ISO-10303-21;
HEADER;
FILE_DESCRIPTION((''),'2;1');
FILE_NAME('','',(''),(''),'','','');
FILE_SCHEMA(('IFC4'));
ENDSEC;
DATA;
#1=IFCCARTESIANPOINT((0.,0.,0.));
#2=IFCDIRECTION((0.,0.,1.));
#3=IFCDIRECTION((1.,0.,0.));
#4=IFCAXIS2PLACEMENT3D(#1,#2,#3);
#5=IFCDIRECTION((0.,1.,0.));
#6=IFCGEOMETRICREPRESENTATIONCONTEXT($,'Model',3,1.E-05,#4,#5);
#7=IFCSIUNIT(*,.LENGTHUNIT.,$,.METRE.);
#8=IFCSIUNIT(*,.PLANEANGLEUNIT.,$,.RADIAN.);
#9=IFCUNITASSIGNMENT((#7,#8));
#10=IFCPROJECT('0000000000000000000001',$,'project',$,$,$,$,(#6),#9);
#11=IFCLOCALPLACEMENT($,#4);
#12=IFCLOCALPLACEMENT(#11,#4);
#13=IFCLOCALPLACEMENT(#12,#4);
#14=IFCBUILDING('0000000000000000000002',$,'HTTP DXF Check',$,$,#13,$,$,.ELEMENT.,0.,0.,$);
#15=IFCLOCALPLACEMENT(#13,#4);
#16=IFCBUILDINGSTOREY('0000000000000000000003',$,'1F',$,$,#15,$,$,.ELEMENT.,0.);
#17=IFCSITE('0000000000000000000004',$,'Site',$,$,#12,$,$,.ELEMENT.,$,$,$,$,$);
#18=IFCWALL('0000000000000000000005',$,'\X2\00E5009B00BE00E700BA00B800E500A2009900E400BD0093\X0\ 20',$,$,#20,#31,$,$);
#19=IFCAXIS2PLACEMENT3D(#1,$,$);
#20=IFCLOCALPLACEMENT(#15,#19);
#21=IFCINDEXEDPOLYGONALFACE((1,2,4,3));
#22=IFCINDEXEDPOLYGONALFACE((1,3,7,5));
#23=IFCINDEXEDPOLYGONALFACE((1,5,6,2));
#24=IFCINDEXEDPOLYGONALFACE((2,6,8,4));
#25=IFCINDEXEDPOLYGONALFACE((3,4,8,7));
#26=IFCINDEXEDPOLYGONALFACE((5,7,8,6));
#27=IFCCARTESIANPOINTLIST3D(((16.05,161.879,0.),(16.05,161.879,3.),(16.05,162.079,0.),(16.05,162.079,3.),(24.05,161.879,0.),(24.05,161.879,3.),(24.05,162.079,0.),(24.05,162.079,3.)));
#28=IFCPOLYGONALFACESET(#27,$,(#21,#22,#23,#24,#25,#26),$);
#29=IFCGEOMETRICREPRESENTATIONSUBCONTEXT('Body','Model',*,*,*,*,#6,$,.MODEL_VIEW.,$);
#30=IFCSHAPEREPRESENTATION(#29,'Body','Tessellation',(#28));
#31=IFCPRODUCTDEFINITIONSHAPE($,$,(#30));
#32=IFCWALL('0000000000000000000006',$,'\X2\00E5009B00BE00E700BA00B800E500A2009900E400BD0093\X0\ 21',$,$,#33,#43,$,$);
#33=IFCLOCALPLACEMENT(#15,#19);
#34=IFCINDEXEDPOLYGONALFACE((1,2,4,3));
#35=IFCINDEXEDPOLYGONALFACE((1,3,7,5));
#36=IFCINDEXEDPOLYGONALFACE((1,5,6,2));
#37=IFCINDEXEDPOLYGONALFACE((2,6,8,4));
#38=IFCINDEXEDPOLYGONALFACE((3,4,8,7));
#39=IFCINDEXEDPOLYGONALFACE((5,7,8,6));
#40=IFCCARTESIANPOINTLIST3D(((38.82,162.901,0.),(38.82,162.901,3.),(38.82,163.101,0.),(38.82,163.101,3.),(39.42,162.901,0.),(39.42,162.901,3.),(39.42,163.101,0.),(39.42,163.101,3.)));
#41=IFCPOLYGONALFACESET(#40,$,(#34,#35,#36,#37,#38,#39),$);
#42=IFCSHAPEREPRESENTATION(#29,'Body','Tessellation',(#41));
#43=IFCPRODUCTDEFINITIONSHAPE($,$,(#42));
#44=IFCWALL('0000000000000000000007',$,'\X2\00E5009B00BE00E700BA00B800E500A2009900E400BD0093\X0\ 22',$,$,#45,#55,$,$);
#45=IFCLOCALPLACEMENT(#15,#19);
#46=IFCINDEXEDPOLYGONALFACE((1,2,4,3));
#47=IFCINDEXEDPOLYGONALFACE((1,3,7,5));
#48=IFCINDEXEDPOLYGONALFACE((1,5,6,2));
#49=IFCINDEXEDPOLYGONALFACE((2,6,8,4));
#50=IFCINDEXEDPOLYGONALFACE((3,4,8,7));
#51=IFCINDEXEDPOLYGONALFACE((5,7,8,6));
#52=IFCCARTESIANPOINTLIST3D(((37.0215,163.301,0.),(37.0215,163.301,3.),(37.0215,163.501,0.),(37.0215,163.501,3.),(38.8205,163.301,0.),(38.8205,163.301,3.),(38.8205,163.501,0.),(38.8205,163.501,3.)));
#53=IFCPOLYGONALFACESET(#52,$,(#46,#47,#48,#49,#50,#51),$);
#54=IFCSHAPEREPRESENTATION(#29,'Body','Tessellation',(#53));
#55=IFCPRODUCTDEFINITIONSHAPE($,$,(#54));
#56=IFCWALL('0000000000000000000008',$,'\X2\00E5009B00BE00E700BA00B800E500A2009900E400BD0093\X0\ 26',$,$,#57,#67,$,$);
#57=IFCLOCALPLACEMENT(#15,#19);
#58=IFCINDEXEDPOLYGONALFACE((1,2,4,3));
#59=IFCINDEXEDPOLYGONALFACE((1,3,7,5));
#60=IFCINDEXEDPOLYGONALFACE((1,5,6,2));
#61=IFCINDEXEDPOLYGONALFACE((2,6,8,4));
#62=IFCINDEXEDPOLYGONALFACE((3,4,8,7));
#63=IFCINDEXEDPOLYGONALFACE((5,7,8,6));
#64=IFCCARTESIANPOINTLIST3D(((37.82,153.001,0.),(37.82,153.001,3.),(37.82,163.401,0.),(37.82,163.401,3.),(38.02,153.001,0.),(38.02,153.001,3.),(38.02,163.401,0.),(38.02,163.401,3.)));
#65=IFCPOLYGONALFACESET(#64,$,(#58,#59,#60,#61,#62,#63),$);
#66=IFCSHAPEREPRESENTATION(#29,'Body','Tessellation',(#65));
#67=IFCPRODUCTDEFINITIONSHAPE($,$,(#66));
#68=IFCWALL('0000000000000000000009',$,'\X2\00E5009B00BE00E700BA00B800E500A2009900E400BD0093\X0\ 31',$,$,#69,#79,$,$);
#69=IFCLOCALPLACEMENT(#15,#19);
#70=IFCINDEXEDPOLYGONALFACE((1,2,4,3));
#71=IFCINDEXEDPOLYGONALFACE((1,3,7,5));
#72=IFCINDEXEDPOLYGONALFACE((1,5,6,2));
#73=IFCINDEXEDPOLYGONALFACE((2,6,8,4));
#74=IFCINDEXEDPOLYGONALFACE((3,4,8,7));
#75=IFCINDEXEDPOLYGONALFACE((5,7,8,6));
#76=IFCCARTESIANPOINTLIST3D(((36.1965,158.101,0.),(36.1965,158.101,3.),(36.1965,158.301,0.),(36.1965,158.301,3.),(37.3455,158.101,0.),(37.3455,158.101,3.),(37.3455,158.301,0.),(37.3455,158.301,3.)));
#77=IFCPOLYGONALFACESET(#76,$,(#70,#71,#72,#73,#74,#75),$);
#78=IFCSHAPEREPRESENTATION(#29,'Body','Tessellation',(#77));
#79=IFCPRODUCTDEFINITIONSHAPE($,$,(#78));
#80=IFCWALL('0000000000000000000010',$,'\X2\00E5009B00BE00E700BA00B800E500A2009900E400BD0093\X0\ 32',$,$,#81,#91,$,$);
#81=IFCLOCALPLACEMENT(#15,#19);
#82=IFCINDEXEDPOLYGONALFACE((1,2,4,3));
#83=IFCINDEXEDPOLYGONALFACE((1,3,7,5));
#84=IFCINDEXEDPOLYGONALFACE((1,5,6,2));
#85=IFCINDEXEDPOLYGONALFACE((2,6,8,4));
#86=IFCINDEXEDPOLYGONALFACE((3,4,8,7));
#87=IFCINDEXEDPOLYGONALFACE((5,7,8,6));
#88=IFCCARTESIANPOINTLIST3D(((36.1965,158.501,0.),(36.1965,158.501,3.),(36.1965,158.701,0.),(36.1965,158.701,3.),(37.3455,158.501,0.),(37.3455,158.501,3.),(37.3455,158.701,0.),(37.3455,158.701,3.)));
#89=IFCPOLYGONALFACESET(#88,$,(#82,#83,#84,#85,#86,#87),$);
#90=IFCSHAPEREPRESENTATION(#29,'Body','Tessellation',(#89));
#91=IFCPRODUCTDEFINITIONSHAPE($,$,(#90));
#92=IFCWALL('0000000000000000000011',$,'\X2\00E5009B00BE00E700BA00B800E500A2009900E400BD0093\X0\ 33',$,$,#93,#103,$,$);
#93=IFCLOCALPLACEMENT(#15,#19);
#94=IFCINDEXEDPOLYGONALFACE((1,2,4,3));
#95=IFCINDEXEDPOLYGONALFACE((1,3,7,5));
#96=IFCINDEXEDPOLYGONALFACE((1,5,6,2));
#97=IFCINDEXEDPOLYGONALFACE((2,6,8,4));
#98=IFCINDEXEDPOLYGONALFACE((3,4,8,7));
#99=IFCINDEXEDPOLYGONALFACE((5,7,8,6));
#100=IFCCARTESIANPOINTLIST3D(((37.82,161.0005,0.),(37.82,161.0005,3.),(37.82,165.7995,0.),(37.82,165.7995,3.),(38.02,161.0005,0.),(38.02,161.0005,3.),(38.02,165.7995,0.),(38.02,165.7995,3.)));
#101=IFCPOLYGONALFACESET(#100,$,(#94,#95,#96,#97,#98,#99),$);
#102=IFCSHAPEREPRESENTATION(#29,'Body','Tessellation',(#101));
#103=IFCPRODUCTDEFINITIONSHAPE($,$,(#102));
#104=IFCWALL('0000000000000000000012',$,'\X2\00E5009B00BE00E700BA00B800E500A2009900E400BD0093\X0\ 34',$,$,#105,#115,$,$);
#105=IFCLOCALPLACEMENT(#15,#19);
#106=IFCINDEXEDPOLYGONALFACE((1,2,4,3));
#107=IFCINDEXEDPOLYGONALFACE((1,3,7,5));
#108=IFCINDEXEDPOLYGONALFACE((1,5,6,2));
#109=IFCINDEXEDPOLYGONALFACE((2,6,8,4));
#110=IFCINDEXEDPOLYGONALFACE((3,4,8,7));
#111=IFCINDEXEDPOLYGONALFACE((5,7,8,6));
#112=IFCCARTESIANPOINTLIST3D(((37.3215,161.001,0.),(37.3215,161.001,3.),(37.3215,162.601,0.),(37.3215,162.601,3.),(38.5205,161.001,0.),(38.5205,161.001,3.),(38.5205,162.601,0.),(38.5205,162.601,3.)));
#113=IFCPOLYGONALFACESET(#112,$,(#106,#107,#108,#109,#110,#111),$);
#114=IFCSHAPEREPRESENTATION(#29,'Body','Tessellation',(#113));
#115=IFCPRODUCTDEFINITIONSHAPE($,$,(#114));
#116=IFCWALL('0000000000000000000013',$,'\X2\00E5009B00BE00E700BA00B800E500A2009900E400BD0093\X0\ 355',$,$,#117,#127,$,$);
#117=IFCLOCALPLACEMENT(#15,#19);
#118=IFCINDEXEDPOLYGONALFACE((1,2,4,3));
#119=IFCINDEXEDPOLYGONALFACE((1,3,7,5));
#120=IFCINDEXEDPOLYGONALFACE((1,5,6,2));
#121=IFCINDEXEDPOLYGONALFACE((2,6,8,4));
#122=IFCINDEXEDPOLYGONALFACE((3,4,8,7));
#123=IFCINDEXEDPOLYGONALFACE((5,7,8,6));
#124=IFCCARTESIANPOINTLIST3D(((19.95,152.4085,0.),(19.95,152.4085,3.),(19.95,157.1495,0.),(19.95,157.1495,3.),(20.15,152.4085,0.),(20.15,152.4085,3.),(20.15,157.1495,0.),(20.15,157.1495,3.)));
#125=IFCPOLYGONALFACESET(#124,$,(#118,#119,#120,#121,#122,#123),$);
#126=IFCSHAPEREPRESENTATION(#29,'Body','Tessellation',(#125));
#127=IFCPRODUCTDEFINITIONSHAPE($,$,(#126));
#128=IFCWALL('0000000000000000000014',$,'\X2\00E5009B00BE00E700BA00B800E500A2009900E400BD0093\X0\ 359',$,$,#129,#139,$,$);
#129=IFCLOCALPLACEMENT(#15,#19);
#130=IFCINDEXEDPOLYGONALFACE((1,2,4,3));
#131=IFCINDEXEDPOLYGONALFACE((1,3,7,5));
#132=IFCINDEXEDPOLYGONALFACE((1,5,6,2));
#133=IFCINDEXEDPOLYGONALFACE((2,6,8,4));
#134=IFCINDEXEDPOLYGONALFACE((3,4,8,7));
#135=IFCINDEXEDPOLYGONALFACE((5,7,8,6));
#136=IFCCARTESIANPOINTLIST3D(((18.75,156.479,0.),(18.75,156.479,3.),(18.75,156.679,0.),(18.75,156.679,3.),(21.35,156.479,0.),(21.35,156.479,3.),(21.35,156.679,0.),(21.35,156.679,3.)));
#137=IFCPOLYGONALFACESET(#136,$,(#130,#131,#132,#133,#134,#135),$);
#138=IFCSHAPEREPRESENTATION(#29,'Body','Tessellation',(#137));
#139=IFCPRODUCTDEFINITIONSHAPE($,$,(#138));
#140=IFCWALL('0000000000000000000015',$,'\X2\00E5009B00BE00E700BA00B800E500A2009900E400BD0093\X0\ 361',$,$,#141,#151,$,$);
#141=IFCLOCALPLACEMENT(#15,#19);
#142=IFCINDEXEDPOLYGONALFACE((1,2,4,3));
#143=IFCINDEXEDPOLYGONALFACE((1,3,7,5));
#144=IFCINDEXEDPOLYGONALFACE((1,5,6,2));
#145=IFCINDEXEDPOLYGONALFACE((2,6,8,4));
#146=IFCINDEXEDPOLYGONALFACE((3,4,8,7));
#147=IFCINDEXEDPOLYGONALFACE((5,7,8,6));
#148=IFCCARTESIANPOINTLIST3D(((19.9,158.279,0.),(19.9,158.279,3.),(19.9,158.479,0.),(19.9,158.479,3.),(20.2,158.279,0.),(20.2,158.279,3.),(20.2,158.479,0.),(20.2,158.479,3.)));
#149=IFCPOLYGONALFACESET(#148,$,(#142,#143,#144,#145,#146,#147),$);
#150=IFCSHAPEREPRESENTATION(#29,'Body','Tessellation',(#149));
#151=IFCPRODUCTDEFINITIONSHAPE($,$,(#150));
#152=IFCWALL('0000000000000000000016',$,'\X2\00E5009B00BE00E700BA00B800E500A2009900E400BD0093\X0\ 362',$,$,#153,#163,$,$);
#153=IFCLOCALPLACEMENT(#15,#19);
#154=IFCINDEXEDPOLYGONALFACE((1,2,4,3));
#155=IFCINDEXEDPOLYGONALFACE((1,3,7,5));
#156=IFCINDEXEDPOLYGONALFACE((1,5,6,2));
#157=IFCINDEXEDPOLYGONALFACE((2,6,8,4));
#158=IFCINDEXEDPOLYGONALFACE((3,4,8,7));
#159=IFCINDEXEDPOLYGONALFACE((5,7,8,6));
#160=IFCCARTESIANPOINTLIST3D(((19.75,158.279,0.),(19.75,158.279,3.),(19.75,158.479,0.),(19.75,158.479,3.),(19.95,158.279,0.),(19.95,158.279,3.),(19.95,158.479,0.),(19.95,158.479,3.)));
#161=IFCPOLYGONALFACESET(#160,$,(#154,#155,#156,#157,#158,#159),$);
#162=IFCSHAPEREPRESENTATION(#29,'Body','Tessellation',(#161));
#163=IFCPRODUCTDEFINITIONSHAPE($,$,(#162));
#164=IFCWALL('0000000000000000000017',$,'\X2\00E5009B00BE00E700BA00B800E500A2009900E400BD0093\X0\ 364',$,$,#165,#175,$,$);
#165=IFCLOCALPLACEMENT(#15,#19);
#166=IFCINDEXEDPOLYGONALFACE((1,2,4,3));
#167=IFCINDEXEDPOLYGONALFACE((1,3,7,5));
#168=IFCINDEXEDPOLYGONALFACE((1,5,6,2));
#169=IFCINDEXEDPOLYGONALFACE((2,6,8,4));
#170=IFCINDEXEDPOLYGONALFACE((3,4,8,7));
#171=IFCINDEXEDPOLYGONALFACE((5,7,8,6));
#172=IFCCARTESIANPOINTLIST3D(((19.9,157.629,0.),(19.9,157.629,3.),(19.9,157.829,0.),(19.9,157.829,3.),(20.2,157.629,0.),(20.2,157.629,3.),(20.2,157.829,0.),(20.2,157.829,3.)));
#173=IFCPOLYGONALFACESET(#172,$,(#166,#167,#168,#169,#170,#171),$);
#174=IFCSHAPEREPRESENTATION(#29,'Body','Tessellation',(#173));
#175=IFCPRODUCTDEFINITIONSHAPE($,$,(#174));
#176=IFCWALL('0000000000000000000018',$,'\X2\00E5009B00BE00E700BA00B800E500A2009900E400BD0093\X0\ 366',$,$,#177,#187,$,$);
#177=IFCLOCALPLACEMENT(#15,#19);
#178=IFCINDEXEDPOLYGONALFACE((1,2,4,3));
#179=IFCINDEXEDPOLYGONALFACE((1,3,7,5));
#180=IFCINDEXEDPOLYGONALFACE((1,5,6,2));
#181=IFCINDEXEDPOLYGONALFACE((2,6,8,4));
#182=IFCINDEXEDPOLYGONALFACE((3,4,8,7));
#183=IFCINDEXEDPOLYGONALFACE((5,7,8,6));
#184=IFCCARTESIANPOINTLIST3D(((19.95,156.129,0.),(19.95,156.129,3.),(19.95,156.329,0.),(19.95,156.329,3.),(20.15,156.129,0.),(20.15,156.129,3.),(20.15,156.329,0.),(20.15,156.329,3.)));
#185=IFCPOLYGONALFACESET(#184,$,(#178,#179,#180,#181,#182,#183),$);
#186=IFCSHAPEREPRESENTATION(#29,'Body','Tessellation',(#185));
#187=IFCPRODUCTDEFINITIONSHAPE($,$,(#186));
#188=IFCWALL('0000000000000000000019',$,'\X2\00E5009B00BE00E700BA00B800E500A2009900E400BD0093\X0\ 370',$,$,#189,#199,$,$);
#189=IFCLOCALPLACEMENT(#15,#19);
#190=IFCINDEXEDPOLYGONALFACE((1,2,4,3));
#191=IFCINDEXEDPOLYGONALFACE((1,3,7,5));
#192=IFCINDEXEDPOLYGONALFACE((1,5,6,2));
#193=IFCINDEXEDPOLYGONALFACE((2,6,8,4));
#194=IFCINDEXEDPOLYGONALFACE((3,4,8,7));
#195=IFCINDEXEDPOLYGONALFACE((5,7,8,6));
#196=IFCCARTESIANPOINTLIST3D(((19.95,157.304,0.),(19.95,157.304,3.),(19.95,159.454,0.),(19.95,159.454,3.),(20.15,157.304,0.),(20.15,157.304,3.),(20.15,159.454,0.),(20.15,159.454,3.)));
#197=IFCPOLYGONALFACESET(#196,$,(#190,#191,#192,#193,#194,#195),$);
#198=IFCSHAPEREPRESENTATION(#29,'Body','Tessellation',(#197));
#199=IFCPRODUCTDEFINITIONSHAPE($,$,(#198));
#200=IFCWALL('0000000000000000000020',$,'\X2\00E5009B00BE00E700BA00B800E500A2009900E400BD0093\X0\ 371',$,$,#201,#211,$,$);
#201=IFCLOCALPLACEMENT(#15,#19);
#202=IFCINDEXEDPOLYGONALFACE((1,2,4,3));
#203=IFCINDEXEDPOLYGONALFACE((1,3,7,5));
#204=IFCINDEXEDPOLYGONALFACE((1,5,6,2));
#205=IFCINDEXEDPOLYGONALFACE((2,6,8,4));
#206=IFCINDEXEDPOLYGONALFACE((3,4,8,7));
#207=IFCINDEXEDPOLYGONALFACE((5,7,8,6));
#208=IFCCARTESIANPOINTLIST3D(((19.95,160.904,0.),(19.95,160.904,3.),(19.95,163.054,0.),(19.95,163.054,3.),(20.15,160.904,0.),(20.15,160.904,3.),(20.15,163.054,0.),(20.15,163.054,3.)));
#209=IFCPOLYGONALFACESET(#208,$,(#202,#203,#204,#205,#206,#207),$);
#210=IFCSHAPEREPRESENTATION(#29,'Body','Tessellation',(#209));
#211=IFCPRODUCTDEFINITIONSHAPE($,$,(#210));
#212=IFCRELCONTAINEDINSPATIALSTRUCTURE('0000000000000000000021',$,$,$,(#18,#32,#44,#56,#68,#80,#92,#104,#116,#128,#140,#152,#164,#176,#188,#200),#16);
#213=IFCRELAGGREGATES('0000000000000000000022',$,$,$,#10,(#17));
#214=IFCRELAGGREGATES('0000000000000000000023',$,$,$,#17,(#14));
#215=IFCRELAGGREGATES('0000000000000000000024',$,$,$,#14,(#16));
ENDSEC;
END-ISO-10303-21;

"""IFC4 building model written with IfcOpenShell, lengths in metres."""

from ifc_helpers import new_model, si_unit, direction, frame, frame_2d, origin_with_axes, place, context, subcontext, project, spatial, rectangle, extrude, element, save


model = new_model("IFC4")

# Units and contexts
model_context = context("Model", 3, precision=1e-05, world=origin_with_axes(), true_north=direction((0.0, 1.0, 0.0)))
body_context = subcontext(model_context, "Body", "Model", "MODEL_VIEW")
ifc_project = project(units=[si_unit("LENGTHUNIT", "METRE"), si_unit("PLANEANGLEUNIT", "RADIAN")], contexts=[model_context])

# Site, building, storey
placement = place(None, origin_with_axes())
site_placement = place(placement, origin_with_axes())
site = spatial("IfcSite", under=ifc_project, at=site_placement, Name="Site", CompositionType="ELEMENT")
building_placement = place(site_placement, origin_with_axes())
building = spatial("IfcBuilding", under=site, at=building_placement, Name="HTTP DXF Check", CompositionType="ELEMENT", ElevationOfRefHeight=0.0, ElevationOfTerrain=0.0)
storey_placement = place(building_placement, origin_with_axes())
storey = spatial("IfcBuildingStorey", under=building, at=storey_placement, Name="1F", CompositionType="ELEMENT", Elevation=0.0)

# Walls
wall_1_placement = place(storey_placement, frame((20.05, 161.979, 0.0), z_axis=(0.0, 0.0, 1.0), x_axis=(-1.0, 0.0, 0.0)))
element("IfcWall", 1, at=wall_1_placement, inside=storey, Name="å\u009b¾çº¸å¢\u0099ä½\u0093 20", context=body_context, shape_type="SweptSolid", body=[
    extrude(rectangle(XDim=8.0, YDim=0.2, at=frame_2d((0.0, 0.0), x_axis=(1.0, 0.0, 0.0))), frame((0.0, 0.0, 0.0), z_axis=(0.0, 0.0, 1.0)), (0.0, 0.0, 1.0), 3.0),
])
wall_2_placement = place(storey_placement, frame((39.12, 163.001, 0.0), z_axis=(0.0, 0.0, 1.0), x_axis=(1.0, 0.0, 0.0)))
element("IfcWall", 2, at=wall_2_placement, inside=storey, Name="å\u009b¾çº¸å¢\u0099ä½\u0093 21", context=body_context, shape_type="SweptSolid", body=[
    extrude(rectangle(XDim=0.6, YDim=0.2, at=frame_2d((0.0, 0.0), x_axis=(1.0, 0.0, 0.0))), frame((0.0, 0.0, 0.0), z_axis=(0.0, 0.0, 1.0)), (0.0, 0.0, 1.0), 3.0),
])
wall_3_placement = place(storey_placement, frame((37.921, 163.401, 0.0), z_axis=(0.0, 0.0, 1.0), x_axis=(1.0, 0.0, 0.0)))
element("IfcWall", 3, at=wall_3_placement, inside=storey, Name="å\u009b¾çº¸å¢\u0099ä½\u0093 22", context=body_context, shape_type="SweptSolid", body=[
    extrude(rectangle(XDim=1.799, YDim=0.2, at=frame_2d((0.0, 0.0), x_axis=(1.0, 0.0, 0.0))), frame((0.0, 0.0, 0.0), z_axis=(0.0, 0.0, 1.0)), (0.0, 0.0, 1.0), 3.0),
])
wall_4_placement = place(storey_placement, frame((37.92, 158.201, 0.0), z_axis=(0.0, 0.0, 1.0), x_axis=(0.0, -1.0, 0.0)))
element("IfcWall", 4, at=wall_4_placement, inside=storey, Name="å\u009b¾çº¸å¢\u0099ä½\u0093 26", context=body_context, shape_type="SweptSolid", body=[
    extrude(rectangle(XDim=10.4, YDim=0.2, at=frame_2d((0.0, 0.0), x_axis=(1.0, 0.0, 0.0))), frame((0.0, 0.0, 0.0), z_axis=(0.0, 0.0, 1.0)), (0.0, 0.0, 1.0), 3.0),
])
for number, where, z_axis, x_axis, name in (
    (5, (36.771, 158.201, 0.0), (0.0, 0.0, 1.0), (1.0, 0.0, 0.0), "å\u009b¾çº¸å¢\u0099ä½\u0093 31"),
    (6, (36.771, 158.601, 0.0), (0.0, 0.0, 1.0), (1.0, 0.0, 0.0), "å\u009b¾çº¸å¢\u0099ä½\u0093 32"),
):
    element("IfcWall", number, at=place(storey_placement, frame(where, z_axis=z_axis, x_axis=x_axis)), inside=storey, Name=name, context=body_context, shape_type="SweptSolid", body=[
        extrude(rectangle(XDim=1.149, YDim=0.2, at=frame_2d((0.0, 0.0), x_axis=(1.0, 0.0, 0.0))), frame((0.0, 0.0, 0.0), z_axis=(0.0, 0.0, 1.0)), (0.0, 0.0, 1.0), 3.0),
    ])
wall_5_placement = place(storey_placement, frame((37.92, 163.4, 0.0), z_axis=(0.0, 0.0, 1.0), x_axis=(0.0, -1.0, 0.0)))
element("IfcWall", 7, at=wall_5_placement, inside=storey, Name="å\u009b¾çº¸å¢\u0099ä½\u0093 33", context=body_context, shape_type="SweptSolid", body=[
    extrude(rectangle(XDim=4.799, YDim=0.2, at=frame_2d((0.0, 0.0), x_axis=(1.0, 0.0, 0.0))), frame((0.0, 0.0, 0.0), z_axis=(0.0, 0.0, 1.0)), (0.0, 0.0, 1.0), 3.0),
])
wall_6_placement = place(storey_placement, frame((37.921, 161.801, 0.0), z_axis=(0.0, 0.0, 1.0), x_axis=(1.0, 0.0, 0.0)))
element("IfcWall", 8, at=wall_6_placement, inside=storey, Name="å\u009b¾çº¸å¢\u0099ä½\u0093 34", context=body_context, shape_type="SweptSolid", body=[
    extrude(rectangle(XDim=1.199, YDim=1.6, at=frame_2d((0.0, 0.0), x_axis=(1.0, 0.0, 0.0))), frame((0.0, 0.0, 0.0), z_axis=(0.0, 0.0, 1.0)), (0.0, 0.0, 1.0), 3.0),
])
wall_7_placement = place(storey_placement, frame((20.05, 154.779, 0.0), z_axis=(0.0, 0.0, 1.0), x_axis=(0.0, -1.0, 0.0)))
element("IfcWall", 9, at=wall_7_placement, inside=storey, Name="å\u009b¾çº¸å¢\u0099ä½\u0093 355", context=body_context, shape_type="SweptSolid", body=[
    extrude(rectangle(XDim=4.741, YDim=0.2, at=frame_2d((0.0, 0.0), x_axis=(1.0, 0.0, 0.0))), frame((0.0, 0.0, 0.0), z_axis=(0.0, 0.0, 1.0)), (0.0, 0.0, 1.0), 3.0),
])
wall_8_placement = place(storey_placement, frame((20.05, 156.579, 0.0), z_axis=(0.0, 0.0, 1.0), x_axis=(-1.0, 0.0, 0.0)))
element("IfcWall", 10, at=wall_8_placement, inside=storey, Name="å\u009b¾çº¸å¢\u0099ä½\u0093 359", context=body_context, shape_type="SweptSolid", body=[
    extrude(rectangle(XDim=2.6, YDim=0.2, at=frame_2d((0.0, 0.0), x_axis=(1.0, 0.0, 0.0))), frame((0.0, 0.0, 0.0), z_axis=(0.0, 0.0, 1.0)), (0.0, 0.0, 1.0), 3.0),
])
wall_9_placement = place(storey_placement, frame((20.05, 158.379, 0.0), z_axis=(0.0, 0.0, 1.0), x_axis=(-1.0, 0.0, 0.0)))
element("IfcWall", 11, at=wall_9_placement, inside=storey, Name="å\u009b¾çº¸å¢\u0099ä½\u0093 361", context=body_context, shape_type="SweptSolid", body=[
    extrude(rectangle(XDim=0.3, YDim=0.2, at=frame_2d((0.0, 0.0), x_axis=(1.0, 0.0, 0.0))), frame((0.0, 0.0, 0.0), z_axis=(0.0, 0.0, 1.0)), (0.0, 0.0, 1.0), 3.0),
])
wall_10_placement = place(storey_placement, frame((19.85, 158.379, 0.0), z_axis=(0.0, 0.0, 1.0), x_axis=(1.0, 0.0, 0.0)))
element("IfcWall", 12, at=wall_10_placement, inside=storey, Name="å\u009b¾çº¸å¢\u0099ä½\u0093 362", context=body_context, shape_type="SweptSolid", body=[
    extrude(rectangle(XDim=0.2, YDim=0.2, at=frame_2d((0.0, 0.0), x_axis=(1.0, 0.0, 0.0))), frame((0.0, 0.0, 0.0), z_axis=(0.0, 0.0, 1.0)), (0.0, 0.0, 1.0), 3.0),
])
for number, where, z_axis, x_axis, name in (
    (13, (20.05, 157.729, 0.0), (0.0, 0.0, 1.0), (-1.0, 0.0, 0.0), "å\u009b¾çº¸å¢\u0099ä½\u0093 364"),
):
    element("IfcWall", number, at=place(storey_placement, frame(where, z_axis=z_axis, x_axis=x_axis)), inside=storey, Name=name, context=body_context, shape_type="SweptSolid", body=[
        extrude(rectangle(XDim=0.3, YDim=0.2, at=frame_2d((0.0, 0.0), x_axis=(1.0, 0.0, 0.0))), frame((0.0, 0.0, 0.0), z_axis=(0.0, 0.0, 1.0)), (0.0, 0.0, 1.0), 3.0),
    ])
wall_11_placement = place(storey_placement, frame((20.05, 156.229, 0.0), z_axis=(0.0, 0.0, 1.0), x_axis=(-1.0, 0.0, 0.0)))
element("IfcWall", 14, at=wall_11_placement, inside=storey, Name="å\u009b¾çº¸å¢\u0099ä½\u0093 366", context=body_context, shape_type="SweptSolid", body=[
    extrude(rectangle(XDim=0.2, YDim=0.2, at=frame_2d((0.0, 0.0), x_axis=(1.0, 0.0, 0.0))), frame((0.0, 0.0, 0.0), z_axis=(0.0, 0.0, 1.0)), (0.0, 0.0, 1.0), 3.0),
])
for number, where, z_axis, x_axis, name in (
    (15, (20.05, 158.379, 0.0), (0.0, 0.0, 1.0), (0.0, -1.0, 0.0), "å\u009b¾çº¸å¢\u0099ä½\u0093 370"),
    (16, (20.05, 161.979, 0.0), (0.0, 0.0, 1.0), (0.0, -1.0, 0.0), "å\u009b¾çº¸å¢\u0099ä½\u0093 371"),
):
    element("IfcWall", number, at=place(storey_placement, frame(where, z_axis=z_axis, x_axis=x_axis)), inside=storey, Name=name, context=body_context, shape_type="SweptSolid", body=[
        extrude(rectangle(XDim=2.15, YDim=0.2, at=frame_2d((0.0, 0.0), x_axis=(1.0, 0.0, 0.0))), frame((0.0, 0.0, 0.0), z_axis=(0.0, 0.0, 1.0)), (0.0, 0.0, 1.0), 3.0),
    ])

save(model, "model.ifc")
